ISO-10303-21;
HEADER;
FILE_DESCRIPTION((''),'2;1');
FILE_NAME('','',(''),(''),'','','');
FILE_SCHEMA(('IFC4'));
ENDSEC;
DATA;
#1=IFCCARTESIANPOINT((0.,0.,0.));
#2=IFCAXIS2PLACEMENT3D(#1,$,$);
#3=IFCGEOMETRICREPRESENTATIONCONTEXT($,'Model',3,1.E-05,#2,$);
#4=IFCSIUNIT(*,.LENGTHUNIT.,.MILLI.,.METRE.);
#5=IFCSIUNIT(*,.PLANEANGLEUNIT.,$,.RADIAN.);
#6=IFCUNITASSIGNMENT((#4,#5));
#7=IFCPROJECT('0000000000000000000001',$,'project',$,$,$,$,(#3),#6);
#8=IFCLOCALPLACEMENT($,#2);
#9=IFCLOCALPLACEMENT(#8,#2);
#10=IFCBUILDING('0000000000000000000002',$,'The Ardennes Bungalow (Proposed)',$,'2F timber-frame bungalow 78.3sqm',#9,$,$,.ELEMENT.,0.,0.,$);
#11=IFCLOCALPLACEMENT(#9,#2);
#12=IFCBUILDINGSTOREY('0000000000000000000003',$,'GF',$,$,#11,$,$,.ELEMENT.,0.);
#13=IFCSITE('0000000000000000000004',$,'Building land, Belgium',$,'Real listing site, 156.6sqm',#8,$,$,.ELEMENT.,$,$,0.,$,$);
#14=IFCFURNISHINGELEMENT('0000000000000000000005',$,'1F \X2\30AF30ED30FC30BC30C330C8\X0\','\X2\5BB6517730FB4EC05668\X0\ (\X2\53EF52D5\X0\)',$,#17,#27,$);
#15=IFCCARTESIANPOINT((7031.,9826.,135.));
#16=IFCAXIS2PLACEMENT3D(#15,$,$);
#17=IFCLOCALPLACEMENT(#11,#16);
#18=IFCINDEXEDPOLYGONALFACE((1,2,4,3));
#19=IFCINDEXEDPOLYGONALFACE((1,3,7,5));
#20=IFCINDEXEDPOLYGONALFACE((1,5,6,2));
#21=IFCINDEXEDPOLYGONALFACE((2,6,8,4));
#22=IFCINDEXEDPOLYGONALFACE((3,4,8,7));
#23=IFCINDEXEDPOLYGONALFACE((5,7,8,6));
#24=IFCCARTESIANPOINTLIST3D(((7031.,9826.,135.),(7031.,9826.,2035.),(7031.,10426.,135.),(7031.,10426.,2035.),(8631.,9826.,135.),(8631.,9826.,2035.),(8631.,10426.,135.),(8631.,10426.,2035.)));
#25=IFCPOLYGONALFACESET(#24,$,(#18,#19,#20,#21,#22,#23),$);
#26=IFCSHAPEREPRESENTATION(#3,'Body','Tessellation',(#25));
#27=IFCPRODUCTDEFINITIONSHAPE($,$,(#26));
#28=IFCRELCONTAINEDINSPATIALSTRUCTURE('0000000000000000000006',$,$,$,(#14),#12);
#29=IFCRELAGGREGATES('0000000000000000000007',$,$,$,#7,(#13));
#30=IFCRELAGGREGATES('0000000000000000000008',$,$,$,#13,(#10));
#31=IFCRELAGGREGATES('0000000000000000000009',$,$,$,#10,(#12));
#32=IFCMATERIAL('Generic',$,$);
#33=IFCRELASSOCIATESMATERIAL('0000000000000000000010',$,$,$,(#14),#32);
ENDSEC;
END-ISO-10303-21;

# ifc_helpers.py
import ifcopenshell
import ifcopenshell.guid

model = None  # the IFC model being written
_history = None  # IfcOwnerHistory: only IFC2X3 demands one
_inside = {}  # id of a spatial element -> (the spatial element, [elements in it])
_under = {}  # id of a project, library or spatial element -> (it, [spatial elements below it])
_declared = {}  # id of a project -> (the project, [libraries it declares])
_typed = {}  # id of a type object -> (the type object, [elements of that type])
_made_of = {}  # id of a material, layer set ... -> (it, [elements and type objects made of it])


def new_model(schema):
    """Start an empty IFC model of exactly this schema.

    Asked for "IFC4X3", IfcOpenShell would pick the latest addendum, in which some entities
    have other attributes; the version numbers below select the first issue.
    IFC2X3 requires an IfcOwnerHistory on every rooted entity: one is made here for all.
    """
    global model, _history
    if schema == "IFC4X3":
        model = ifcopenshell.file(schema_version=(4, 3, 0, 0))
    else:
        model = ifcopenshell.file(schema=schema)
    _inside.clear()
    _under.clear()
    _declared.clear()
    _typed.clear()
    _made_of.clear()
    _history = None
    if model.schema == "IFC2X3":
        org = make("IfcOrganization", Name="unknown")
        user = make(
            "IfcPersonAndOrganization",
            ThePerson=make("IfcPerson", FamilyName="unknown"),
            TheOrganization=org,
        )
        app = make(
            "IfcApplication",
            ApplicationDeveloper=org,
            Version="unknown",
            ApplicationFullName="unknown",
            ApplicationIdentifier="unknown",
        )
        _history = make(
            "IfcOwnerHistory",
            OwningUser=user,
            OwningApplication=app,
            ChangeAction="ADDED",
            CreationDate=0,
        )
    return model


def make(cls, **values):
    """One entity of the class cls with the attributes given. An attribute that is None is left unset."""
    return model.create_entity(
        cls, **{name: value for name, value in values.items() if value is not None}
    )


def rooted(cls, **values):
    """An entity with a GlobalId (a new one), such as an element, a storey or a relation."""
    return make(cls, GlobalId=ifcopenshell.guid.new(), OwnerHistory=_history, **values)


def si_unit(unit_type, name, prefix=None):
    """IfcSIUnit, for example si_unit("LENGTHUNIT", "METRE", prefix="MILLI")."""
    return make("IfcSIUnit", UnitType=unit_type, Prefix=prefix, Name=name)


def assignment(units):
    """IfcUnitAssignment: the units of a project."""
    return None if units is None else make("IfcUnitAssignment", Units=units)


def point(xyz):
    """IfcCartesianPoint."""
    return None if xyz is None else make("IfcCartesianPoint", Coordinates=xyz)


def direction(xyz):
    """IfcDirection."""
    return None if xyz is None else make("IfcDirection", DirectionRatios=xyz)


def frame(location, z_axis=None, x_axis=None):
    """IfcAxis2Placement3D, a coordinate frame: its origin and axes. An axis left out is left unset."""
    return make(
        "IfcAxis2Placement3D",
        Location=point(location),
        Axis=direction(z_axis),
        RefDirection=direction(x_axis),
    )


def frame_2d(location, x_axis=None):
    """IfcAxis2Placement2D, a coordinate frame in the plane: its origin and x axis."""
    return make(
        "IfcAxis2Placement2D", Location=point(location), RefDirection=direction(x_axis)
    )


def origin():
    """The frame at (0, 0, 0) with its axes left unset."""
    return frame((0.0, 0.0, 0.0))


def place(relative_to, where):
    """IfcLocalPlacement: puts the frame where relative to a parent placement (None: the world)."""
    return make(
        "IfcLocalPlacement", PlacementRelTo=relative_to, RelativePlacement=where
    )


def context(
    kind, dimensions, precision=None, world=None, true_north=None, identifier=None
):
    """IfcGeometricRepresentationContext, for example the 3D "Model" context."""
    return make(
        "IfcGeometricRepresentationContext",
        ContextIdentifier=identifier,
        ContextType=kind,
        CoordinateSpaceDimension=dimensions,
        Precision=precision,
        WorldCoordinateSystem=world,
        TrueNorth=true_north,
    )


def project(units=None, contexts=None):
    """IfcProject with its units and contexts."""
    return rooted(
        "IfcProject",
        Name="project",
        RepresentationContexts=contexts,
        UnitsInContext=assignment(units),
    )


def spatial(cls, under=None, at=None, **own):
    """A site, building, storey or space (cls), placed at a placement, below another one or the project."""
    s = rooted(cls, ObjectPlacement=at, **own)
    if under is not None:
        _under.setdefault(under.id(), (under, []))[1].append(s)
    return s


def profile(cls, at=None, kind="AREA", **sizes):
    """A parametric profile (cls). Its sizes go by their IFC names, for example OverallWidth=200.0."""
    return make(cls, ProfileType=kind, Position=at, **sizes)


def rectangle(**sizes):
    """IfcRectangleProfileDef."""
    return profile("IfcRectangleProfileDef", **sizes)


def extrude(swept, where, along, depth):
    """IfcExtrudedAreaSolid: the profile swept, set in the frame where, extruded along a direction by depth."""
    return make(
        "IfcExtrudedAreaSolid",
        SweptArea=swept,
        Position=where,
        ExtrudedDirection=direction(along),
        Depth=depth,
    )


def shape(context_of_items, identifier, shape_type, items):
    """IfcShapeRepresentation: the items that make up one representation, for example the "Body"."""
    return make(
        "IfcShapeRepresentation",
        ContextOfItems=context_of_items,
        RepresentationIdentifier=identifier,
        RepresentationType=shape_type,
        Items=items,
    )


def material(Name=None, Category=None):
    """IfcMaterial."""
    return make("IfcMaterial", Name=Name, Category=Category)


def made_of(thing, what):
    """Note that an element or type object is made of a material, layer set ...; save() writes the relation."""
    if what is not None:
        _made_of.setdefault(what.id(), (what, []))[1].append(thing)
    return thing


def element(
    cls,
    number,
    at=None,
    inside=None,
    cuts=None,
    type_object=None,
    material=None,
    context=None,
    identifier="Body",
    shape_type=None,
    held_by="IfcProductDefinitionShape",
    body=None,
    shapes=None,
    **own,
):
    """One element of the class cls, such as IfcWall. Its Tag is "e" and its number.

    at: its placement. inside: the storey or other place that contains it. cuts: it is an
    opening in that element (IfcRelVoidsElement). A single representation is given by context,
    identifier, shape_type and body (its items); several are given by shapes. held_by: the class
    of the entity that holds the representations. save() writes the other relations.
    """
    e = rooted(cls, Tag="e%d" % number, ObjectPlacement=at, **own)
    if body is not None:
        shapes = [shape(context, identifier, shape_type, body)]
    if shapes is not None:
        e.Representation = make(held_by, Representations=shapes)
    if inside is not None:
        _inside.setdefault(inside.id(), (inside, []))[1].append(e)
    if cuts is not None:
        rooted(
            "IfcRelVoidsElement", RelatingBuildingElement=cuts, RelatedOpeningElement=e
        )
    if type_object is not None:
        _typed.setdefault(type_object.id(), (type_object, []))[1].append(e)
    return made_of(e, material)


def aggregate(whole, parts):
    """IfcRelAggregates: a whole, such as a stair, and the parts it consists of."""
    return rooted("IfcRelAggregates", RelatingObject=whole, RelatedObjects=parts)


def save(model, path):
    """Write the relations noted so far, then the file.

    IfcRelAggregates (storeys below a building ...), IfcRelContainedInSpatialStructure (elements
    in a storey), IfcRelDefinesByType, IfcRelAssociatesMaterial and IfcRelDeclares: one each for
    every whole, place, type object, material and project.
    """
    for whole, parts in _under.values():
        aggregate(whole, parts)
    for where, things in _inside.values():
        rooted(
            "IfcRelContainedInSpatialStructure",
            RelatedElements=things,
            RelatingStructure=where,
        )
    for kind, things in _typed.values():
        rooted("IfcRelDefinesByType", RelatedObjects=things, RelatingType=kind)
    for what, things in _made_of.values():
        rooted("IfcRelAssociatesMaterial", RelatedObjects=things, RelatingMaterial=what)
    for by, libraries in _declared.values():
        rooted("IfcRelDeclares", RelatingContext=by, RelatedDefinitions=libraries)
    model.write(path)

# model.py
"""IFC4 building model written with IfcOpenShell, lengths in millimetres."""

from ifc_helpers import new_model, si_unit, frame, frame_2d, origin, place, context, project, spatial, rectangle, extrude, material, element, save


model = new_model("IFC4")

# Units and contexts
model_context = context("Model", 3, precision=1e-05, world=origin())
ifc_project = project(units=[si_unit("LENGTHUNIT", "METRE", prefix="MILLI"), si_unit("PLANEANGLEUNIT", "RADIAN")], contexts=[model_context])

# Site, building, storey
site_placement = place(None, origin())
site = spatial("IfcSite", under=ifc_project, at=site_placement, Name="Building land, Belgium", ObjectType="Real listing site, 156.6sqm", CompositionType="ELEMENT", RefElevation=0.0)
building_placement = place(site_placement, origin())
building = spatial("IfcBuilding", under=site, at=building_placement, Name="The Ardennes Bungalow (Proposed)", ObjectType="2F timber-frame bungalow 78.3sqm", CompositionType="ELEMENT", ElevationOfRefHeight=0.0, ElevationOfTerrain=0.0)
storey_placement = place(building_placement, origin())
storey = spatial("IfcBuildingStorey", under=building, at=storey_placement, Name="GF", CompositionType="ELEMENT", Elevation=0.0)

# Shared definitions
ifc_material_1 = material(Name="Generic")

# Furnishing element
furnishing_placement = place(storey_placement, frame((7031.0, 9826.0, 135.0)))
element("IfcFurnishingElement", 1, at=furnishing_placement, inside=storey, material=ifc_material_1, Name="1F クローゼット", Description="家具・什器 (可動)", context=model_context, shape_type="SweptSolid", body=[
    extrude(rectangle(XDim=1600.0, YDim=600.0, at=frame_2d((800.0, 300.0))), frame((7031.0, 9826.0, 135.0)), (0.0, 0.0, 1.0), 1900.0),
])

save(model, "model.ifc")
